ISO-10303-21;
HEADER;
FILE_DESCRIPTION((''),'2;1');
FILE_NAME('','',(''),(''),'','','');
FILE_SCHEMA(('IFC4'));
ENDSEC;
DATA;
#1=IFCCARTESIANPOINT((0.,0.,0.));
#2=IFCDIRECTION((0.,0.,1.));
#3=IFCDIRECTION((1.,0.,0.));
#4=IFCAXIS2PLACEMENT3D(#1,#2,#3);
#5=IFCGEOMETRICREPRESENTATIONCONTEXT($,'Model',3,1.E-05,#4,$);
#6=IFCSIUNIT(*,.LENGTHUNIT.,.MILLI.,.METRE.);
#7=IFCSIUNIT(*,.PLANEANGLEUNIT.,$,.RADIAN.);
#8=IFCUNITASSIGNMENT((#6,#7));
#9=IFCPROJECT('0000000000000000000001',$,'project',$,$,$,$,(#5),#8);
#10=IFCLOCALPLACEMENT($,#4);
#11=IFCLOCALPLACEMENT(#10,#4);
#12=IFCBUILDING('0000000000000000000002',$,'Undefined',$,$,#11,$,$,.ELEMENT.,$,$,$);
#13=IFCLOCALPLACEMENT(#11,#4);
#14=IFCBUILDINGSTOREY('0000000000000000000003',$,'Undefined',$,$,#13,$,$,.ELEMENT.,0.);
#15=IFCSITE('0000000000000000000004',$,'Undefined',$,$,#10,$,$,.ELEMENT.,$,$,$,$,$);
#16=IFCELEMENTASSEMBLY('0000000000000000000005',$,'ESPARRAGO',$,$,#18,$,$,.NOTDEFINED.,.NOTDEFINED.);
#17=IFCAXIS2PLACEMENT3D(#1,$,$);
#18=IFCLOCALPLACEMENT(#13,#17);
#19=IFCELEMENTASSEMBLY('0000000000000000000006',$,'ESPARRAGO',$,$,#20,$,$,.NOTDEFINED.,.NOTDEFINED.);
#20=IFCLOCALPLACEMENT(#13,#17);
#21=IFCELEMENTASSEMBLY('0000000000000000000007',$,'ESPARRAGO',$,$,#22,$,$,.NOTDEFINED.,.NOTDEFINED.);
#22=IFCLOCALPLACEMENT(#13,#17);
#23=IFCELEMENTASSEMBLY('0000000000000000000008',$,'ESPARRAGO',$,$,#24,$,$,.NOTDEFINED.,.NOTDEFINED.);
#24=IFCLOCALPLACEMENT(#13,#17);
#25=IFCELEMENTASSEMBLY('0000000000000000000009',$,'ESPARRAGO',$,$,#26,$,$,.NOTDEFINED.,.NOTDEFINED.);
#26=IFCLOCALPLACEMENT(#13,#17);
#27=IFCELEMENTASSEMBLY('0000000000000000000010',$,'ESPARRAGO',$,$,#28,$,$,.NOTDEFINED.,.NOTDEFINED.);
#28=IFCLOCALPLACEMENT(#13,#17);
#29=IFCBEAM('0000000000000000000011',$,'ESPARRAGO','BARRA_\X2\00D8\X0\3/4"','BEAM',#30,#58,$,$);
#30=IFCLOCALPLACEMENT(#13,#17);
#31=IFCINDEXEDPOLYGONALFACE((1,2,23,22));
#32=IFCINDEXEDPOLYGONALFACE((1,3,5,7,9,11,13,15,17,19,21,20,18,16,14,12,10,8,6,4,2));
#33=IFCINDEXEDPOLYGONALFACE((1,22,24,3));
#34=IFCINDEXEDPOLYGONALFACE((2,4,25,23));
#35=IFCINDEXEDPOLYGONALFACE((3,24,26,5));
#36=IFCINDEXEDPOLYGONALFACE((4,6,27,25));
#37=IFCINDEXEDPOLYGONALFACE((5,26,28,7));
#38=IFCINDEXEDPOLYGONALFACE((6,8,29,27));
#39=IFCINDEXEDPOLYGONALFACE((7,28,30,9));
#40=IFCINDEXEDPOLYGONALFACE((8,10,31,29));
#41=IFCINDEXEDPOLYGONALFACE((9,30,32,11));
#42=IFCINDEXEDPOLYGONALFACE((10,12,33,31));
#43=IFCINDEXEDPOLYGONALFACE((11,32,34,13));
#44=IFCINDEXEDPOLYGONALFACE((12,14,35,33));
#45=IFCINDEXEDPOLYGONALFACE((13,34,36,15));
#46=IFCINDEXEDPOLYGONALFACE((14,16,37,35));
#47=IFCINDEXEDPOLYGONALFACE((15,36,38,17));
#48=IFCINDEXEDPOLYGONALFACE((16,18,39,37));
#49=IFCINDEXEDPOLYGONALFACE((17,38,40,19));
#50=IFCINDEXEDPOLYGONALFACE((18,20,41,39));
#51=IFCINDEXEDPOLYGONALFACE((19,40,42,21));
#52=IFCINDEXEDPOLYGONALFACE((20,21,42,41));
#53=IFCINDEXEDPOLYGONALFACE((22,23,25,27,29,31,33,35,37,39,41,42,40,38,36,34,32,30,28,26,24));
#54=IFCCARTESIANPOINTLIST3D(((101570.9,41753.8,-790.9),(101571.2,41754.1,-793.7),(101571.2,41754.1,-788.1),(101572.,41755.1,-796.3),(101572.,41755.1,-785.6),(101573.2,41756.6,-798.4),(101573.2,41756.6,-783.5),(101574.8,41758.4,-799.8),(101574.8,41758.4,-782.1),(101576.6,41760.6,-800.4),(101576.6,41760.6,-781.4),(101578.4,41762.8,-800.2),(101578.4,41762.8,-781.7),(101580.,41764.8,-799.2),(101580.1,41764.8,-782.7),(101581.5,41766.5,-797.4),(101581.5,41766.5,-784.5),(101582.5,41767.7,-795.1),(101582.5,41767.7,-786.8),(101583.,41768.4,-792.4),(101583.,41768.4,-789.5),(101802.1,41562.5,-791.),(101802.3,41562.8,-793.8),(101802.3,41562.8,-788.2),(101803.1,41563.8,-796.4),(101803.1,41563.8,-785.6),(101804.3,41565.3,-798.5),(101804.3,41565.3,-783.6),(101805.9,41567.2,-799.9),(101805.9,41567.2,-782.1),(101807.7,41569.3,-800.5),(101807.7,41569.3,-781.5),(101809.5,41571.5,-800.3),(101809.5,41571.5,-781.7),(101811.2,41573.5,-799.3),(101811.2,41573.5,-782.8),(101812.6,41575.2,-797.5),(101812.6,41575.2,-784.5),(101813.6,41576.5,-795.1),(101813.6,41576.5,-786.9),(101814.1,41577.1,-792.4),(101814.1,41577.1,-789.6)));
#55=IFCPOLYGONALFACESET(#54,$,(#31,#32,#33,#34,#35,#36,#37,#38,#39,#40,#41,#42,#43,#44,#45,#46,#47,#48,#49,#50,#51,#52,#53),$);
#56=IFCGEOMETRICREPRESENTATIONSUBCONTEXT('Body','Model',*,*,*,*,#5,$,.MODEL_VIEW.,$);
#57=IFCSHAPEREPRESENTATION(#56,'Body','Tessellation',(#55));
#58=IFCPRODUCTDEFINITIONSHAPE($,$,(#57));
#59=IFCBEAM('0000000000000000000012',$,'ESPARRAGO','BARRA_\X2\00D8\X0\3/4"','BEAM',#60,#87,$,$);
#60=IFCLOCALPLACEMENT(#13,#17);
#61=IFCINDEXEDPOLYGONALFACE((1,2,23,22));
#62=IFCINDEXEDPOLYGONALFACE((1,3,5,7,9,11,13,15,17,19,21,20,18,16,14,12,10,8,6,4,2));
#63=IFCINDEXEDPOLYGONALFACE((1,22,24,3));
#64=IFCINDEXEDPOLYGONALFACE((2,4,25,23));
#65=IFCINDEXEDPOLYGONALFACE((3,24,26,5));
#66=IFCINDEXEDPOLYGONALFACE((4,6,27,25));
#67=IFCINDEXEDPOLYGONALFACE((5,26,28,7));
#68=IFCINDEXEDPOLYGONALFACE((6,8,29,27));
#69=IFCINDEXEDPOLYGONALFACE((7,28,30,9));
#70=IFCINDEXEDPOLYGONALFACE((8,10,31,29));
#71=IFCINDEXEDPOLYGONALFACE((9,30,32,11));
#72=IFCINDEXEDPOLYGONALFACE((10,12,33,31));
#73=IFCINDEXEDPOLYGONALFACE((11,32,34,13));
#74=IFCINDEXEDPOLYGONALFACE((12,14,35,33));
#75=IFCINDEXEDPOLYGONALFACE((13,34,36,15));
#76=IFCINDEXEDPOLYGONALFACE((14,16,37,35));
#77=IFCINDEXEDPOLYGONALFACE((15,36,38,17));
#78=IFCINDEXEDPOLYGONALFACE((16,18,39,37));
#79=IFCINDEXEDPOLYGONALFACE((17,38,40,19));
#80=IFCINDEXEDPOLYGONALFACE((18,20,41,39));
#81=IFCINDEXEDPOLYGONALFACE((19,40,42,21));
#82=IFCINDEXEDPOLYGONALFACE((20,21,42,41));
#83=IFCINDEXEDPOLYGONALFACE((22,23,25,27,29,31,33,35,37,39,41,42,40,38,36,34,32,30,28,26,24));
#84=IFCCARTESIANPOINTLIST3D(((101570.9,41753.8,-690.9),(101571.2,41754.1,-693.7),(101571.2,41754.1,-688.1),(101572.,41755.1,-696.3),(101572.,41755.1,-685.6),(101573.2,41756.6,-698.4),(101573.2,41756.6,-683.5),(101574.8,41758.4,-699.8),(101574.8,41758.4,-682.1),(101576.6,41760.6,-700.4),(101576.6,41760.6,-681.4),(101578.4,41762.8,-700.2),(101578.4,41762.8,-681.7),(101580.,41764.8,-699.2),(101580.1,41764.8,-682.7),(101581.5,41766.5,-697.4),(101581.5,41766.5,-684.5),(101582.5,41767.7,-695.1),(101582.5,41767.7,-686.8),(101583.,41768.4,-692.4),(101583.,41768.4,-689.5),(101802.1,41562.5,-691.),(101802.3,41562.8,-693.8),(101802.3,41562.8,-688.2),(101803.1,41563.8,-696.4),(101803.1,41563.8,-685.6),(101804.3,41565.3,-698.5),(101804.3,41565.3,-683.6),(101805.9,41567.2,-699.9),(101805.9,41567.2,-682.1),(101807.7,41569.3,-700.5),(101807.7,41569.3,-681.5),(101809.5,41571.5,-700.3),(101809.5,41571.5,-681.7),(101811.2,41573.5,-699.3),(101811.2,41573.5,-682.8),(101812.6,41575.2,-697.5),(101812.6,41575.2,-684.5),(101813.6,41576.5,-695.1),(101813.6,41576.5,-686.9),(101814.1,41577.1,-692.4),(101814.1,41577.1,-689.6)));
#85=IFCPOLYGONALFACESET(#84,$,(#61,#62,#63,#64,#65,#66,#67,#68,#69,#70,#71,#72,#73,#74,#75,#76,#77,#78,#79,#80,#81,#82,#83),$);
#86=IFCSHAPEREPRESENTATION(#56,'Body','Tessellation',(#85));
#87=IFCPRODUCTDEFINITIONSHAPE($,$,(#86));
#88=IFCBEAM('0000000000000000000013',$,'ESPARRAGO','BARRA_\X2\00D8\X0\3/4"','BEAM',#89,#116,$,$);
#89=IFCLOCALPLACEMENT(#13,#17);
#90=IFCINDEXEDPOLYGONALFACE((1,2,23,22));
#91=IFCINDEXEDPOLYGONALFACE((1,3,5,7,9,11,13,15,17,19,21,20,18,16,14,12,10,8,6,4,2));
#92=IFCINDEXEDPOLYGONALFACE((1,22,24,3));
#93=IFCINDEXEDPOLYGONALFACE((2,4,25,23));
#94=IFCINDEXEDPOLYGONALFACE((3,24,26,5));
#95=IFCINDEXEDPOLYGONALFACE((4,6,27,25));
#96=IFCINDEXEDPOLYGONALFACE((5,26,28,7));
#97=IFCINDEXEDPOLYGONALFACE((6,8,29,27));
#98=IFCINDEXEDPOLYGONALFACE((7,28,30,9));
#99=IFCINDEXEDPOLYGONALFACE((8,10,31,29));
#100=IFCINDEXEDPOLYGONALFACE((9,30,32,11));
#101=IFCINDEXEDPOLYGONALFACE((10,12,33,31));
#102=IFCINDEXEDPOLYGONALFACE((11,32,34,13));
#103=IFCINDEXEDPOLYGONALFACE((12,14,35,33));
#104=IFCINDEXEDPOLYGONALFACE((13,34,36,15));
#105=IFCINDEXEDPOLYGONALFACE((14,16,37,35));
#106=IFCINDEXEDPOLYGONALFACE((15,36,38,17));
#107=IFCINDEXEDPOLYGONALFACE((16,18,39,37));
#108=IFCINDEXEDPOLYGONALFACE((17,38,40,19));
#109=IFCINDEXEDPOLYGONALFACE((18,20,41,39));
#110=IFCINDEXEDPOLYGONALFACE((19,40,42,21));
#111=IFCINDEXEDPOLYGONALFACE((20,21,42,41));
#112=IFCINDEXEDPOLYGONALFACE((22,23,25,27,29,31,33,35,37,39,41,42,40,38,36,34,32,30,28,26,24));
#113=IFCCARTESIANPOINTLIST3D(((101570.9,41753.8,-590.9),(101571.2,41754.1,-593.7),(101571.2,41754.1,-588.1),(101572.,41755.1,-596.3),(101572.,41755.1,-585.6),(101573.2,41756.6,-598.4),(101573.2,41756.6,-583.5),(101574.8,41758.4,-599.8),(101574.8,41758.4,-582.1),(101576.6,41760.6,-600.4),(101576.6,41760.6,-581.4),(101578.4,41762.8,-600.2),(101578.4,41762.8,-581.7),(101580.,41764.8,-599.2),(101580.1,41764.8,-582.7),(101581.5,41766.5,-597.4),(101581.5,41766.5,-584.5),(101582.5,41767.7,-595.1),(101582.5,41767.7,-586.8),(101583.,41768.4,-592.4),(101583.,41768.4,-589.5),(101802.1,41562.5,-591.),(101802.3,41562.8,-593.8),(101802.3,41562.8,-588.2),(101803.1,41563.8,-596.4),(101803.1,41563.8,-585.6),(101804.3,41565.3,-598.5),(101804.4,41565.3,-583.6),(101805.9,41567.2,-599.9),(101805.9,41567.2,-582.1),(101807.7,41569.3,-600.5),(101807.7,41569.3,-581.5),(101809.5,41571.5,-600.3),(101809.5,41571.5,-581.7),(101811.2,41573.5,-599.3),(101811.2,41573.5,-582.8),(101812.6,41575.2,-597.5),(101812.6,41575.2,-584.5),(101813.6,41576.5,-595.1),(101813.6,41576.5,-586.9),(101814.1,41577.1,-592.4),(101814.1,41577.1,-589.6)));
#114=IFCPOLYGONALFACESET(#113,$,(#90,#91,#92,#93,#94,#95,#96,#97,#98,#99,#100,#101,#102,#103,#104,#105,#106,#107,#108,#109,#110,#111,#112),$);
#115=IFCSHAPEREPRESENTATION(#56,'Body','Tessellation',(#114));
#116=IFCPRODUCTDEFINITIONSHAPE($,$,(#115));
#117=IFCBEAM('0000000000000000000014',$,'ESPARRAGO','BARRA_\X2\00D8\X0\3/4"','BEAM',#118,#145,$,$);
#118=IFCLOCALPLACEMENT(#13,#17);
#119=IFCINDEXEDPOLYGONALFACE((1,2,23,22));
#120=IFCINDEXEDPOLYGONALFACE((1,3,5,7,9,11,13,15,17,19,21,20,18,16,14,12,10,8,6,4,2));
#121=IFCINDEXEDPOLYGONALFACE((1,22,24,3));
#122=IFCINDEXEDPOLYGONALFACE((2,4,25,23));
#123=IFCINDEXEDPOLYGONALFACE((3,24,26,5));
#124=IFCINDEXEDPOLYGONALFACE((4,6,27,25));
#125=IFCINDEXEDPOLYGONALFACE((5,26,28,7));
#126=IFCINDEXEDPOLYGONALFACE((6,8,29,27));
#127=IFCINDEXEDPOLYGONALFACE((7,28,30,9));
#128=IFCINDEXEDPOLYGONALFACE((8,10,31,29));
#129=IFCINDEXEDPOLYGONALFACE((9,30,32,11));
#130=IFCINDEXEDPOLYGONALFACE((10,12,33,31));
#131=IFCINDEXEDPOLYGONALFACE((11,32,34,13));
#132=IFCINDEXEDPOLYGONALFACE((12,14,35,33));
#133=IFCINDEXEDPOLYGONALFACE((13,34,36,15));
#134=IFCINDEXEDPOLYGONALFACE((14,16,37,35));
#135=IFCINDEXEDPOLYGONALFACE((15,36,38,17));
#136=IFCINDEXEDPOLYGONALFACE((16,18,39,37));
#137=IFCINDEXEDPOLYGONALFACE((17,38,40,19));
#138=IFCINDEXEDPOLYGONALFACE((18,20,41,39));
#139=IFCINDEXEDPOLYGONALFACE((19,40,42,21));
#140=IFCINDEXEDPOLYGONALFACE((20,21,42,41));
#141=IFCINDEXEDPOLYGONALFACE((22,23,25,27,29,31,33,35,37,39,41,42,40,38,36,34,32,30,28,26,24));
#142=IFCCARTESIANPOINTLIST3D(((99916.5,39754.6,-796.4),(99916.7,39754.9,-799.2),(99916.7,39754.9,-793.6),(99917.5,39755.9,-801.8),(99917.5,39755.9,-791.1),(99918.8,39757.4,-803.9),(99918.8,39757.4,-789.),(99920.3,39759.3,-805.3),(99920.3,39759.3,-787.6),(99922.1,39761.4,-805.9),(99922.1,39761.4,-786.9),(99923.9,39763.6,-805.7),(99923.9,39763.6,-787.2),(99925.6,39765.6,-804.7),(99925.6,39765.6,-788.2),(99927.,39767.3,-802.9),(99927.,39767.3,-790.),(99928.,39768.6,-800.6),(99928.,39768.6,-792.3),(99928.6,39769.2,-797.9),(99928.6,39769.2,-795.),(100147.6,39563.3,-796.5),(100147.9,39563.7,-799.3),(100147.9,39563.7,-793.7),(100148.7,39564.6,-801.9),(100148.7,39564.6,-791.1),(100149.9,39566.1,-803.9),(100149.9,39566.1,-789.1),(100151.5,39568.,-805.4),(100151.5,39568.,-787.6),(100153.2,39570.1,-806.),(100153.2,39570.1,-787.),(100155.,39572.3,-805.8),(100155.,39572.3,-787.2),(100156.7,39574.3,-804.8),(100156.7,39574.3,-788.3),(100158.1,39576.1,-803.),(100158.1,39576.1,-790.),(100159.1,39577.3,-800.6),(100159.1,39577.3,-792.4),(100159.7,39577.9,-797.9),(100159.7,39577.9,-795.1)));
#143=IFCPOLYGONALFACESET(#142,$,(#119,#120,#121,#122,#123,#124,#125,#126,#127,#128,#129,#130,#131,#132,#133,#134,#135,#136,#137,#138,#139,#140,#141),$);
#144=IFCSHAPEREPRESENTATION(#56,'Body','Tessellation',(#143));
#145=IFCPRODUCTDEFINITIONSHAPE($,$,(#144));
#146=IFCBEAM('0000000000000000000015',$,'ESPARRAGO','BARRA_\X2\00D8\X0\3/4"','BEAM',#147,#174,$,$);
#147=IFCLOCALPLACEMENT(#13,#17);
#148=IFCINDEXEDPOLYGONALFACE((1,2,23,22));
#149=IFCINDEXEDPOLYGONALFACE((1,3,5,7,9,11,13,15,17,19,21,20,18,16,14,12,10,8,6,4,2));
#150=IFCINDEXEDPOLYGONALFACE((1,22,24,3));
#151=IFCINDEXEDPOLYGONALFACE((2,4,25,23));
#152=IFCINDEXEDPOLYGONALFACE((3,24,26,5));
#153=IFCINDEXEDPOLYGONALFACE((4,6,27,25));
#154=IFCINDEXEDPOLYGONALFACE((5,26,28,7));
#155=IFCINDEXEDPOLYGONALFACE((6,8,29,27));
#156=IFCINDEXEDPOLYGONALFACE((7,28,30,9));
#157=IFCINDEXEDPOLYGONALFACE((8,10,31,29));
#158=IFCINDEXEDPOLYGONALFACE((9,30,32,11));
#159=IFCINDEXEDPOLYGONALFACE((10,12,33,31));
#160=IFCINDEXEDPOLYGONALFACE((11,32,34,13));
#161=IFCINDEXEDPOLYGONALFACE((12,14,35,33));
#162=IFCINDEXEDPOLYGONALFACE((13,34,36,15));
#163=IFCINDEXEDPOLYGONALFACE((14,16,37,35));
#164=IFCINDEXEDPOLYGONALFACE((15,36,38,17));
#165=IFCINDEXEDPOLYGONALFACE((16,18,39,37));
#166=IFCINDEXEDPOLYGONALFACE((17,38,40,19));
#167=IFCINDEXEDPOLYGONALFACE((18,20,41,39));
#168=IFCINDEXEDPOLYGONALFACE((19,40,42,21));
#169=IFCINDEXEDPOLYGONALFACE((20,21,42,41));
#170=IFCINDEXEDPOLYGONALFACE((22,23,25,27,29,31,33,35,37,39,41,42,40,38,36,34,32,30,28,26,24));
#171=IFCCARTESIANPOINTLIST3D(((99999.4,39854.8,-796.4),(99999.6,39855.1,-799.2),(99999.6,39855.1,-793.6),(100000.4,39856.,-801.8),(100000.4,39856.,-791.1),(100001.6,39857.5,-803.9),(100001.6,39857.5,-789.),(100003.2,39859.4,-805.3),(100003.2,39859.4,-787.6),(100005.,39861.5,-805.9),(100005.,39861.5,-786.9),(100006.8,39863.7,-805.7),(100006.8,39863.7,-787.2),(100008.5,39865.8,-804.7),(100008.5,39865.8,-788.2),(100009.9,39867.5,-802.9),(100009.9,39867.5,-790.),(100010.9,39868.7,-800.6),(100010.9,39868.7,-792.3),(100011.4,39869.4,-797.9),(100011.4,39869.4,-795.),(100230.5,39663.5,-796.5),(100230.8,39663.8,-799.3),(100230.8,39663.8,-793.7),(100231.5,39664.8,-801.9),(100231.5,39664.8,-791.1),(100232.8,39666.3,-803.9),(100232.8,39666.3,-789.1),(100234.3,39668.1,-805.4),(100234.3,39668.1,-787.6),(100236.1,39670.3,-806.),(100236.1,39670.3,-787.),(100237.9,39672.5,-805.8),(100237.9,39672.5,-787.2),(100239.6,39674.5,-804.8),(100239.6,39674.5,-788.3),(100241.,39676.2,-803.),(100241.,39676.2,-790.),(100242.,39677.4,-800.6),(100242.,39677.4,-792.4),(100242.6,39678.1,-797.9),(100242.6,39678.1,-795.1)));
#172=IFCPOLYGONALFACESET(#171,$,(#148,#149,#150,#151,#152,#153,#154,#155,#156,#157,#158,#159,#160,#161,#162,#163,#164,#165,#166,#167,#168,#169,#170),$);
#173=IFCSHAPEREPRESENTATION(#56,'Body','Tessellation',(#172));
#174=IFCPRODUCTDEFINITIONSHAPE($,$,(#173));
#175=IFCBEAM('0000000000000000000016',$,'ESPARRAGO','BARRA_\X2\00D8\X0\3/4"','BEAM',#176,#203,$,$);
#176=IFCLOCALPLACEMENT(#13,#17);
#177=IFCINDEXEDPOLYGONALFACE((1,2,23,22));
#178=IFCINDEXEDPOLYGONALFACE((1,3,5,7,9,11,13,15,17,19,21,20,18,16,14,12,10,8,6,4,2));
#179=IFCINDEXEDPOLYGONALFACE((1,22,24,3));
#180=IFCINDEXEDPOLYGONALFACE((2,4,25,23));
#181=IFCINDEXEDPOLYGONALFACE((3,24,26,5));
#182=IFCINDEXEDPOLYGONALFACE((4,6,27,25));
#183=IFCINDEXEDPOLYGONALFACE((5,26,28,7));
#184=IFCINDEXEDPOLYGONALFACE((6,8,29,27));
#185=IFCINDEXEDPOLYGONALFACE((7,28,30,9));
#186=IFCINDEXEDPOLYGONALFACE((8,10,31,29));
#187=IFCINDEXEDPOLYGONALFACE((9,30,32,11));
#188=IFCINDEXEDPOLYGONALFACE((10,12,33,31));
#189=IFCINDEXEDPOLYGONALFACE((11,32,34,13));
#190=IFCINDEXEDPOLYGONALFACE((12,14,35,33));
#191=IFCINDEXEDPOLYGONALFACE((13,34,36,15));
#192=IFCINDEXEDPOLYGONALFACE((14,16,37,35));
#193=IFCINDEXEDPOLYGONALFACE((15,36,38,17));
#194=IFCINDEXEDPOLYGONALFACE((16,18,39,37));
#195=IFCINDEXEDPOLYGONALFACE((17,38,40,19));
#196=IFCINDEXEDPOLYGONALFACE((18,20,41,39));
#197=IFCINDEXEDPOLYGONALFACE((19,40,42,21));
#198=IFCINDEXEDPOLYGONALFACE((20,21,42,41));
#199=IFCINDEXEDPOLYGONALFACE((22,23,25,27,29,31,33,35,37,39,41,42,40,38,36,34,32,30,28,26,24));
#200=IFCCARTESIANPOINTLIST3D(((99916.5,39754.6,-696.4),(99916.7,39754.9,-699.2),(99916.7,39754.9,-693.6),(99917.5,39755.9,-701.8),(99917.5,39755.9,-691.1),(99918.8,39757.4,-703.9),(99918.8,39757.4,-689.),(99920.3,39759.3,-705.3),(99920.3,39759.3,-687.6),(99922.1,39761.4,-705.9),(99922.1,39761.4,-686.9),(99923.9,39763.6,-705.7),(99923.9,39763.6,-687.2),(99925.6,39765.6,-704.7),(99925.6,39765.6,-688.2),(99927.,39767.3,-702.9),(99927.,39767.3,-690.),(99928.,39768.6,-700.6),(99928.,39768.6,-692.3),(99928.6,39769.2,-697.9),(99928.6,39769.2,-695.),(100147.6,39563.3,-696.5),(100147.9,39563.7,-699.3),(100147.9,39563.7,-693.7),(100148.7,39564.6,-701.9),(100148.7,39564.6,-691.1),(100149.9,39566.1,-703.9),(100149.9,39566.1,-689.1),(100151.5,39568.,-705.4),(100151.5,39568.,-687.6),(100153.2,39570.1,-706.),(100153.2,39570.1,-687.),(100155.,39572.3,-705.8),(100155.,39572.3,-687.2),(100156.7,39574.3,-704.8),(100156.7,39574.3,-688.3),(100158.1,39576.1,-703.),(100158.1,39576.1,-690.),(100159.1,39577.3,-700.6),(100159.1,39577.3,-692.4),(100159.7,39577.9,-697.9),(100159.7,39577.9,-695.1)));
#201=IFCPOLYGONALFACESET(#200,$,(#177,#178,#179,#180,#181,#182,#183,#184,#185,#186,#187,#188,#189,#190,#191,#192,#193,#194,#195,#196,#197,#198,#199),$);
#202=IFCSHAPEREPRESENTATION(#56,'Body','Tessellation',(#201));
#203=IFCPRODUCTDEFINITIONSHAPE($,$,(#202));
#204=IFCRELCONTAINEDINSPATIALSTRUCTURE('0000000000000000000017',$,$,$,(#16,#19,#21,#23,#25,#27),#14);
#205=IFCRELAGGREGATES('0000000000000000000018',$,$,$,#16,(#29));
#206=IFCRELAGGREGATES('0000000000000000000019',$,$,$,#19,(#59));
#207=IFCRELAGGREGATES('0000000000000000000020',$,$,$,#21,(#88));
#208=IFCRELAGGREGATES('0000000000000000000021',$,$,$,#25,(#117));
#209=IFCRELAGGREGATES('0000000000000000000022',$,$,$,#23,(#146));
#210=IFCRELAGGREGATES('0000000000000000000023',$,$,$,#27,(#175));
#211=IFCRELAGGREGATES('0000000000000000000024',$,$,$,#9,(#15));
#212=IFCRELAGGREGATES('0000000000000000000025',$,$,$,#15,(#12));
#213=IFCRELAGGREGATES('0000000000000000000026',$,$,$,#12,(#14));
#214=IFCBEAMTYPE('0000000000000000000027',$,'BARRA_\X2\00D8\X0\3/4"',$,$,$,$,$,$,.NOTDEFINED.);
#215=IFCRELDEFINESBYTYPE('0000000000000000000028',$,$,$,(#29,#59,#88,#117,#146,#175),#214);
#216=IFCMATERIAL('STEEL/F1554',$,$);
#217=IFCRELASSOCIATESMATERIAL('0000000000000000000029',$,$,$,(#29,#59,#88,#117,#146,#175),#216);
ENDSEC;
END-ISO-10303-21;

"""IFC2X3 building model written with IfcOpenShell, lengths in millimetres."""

from ifc_helpers import new_model, si_unit, frame, origin_with_axes, origin_2d_with_axis, place, context, subcontext, project, spatial, circle, extrude, material, type_object, element, aggregate, save


model = new_model("IFC2X3")

# Units and contexts
model_context = context("Model", 3, precision=1e-05, world=origin_with_axes())
body_context = subcontext(model_context, "Body", "Model", "MODEL_VIEW")
ifc_project = project(units=[si_unit("LENGTHUNIT", "METRE", prefix="MILLI"), si_unit("PLANEANGLEUNIT", "RADIAN")], contexts=[model_context])

# Site, building, storey
site_placement = place(None, origin_with_axes())
site = spatial("IfcSite", under=ifc_project, at=site_placement, Name="Undefined", CompositionType="ELEMENT")
building_placement = place(site_placement, origin_with_axes())
building = spatial("IfcBuilding", under=site, at=building_placement, Name="Undefined", CompositionType="ELEMENT")
storey_placement = place(building_placement, origin_with_axes())
storey = spatial("IfcBuildingStorey", under=building, at=storey_placement, Name="Undefined", CompositionType="ELEMENT", Elevation=0.0)

# Element assemblies
assembly_1_placement = place(storey_placement, origin_with_axes())
assembly_1 = element("IfcElementAssembly", 1, at=assembly_1_placement, inside=storey, Name="ESPARRAGO", AssemblyPlace="NOTDEFINED", PredefinedType="NOTDEFINED")
assembly_2_placement = place(storey_placement, origin_with_axes())
assembly_2 = element("IfcElementAssembly", 2, at=assembly_2_placement, inside=storey, Name="ESPARRAGO", AssemblyPlace="NOTDEFINED", PredefinedType="NOTDEFINED")
assembly_3_placement = place(storey_placement, origin_with_axes())
assembly_3 = element("IfcElementAssembly", 3, at=assembly_3_placement, inside=storey, Name="ESPARRAGO", AssemblyPlace="NOTDEFINED", PredefinedType="NOTDEFINED")
assembly_4_placement = place(storey_placement, origin_with_axes())
assembly_4 = element("IfcElementAssembly", 4, at=assembly_4_placement, inside=storey, Name="ESPARRAGO", AssemblyPlace="NOTDEFINED", PredefinedType="NOTDEFINED")

# Element assembly
assembly_5_placement = place(storey_placement, origin_with_axes())
assembly_5 = element("IfcElementAssembly", 5, at=assembly_5_placement, inside=storey, Name="ESPARRAGO", AssemblyPlace="NOTDEFINED", PredefinedType="NOTDEFINED")

# Element assembly
assembly_6_placement = place(storey_placement, origin_with_axes())
assembly_6 = element("IfcElementAssembly", 6, at=assembly_6_placement, inside=storey, Name="ESPARRAGO", AssemblyPlace="NOTDEFINED", PredefinedType="NOTDEFINED")

# Beams
ifc_material_1 = material(Name="STEEL/F1554")
beam_type_1 = type_object("IfcBeamType", Name="BARRA_Ø3/4\"", PredefinedType="NOTDEFINED")
beam_1_placement = place(assembly_1_placement, frame((101577.0, 41761.1, -790.9), z_axis=(0.000162, -0.000134, 1.0), x_axis=(0.770403, -0.637558, -0.000211)))
beam_1 = element("IfcBeam", 7, at=beam_1_placement, type_object=beam_type_1, material=ifc_material_1, Name="ESPARRAGO", Description="BARRA_Ø3/4\"", ObjectType="BEAM", context=body_context, shape_type="SweptSolid", body=[
    extrude(circle(Radius=9.5, at=origin_2d_with_axis()), frame((300.0, 0.0, 0.0), z_axis=(-1.0, 0.0, 0.0), x_axis=(0.0, -1.0, 0.0)), (0.0, 0.0, 1.0), 300.0),
])
aggregate(assembly_1, [beam_1])
beam_2_placement = place(assembly_2_placement, frame((101577.0, 41761.1, -690.9), z_axis=(0.000162, -0.000134, 1.0), x_axis=(0.770403, -0.637558, -0.000211)))
beam_2 = element("IfcBeam", 8, at=beam_2_placement, type_object=beam_type_1, material=ifc_material_1, Name="ESPARRAGO", Description="BARRA_Ø3/4\"", ObjectType="BEAM", context=body_context, shape_type="SweptSolid", body=[
    extrude(circle(Radius=9.5, at=origin_2d_with_axis()), frame((300.0, 0.0, 0.0), z_axis=(-1.0, 0.0, 0.0), x_axis=(0.0, -1.0, 0.0)), (0.0, 0.0, 1.0), 300.0),
])
aggregate(assembly_2, [beam_2])
beam_3_placement = place(assembly_3_placement, frame((101577.0, 41761.1, -590.9), z_axis=(0.000162, -0.000134, 1.0), x_axis=(0.770403, -0.637558, -0.000211)))
beam_3 = element("IfcBeam", 9, at=beam_3_placement, type_object=beam_type_1, material=ifc_material_1, Name="ESPARRAGO", Description="BARRA_Ø3/4\"", ObjectType="BEAM", context=body_context, shape_type="SweptSolid", body=[
    extrude(circle(Radius=9.5, at=origin_2d_with_axis()), frame((300.0, 0.0, 0.0), z_axis=(-1.0, 0.0, 0.0), x_axis=(0.0, -1.0, 0.0)), (0.0, 0.0, 1.0), 300.0),
])
aggregate(assembly_3, [beam_3])
beam_4_placement = place(assembly_5_placement, frame((99922.6, 39761.9, -796.4), z_axis=(0.000162, -0.000134, 1.0), x_axis=(0.770403, -0.637558, -0.000211)))
beam_4 = element("IfcBeam", 10, at=beam_4_placement, type_object=beam_type_1, material=ifc_material_1, Name="ESPARRAGO", Description="BARRA_Ø3/4\"", ObjectType="BEAM", context=body_context, shape_type="SweptSolid", body=[
    extrude(circle(Radius=9.5, at=origin_2d_with_axis()), frame((300.0, 0.0, 0.0), z_axis=(-1.0, 0.0, 0.0), x_axis=(0.0, -1.0, 0.0)), (0.0, 0.0, 1.0), 300.0),
])
aggregate(assembly_5, [beam_4])
beam_5_placement = place(assembly_4_placement, frame((100005.4, 39862.1, -796.4), z_axis=(0.000162, -0.000134, 1.0), x_axis=(0.770403, -0.637558, -0.000211)))
beam_5 = element("IfcBeam", 11, at=beam_5_placement, type_object=beam_type_1, material=ifc_material_1, Name="ESPARRAGO", Description="BARRA_Ø3/4\"", ObjectType="BEAM", context=body_context, shape_type="SweptSolid", body=[
    extrude(circle(Radius=9.5, at=origin_2d_with_axis()), frame((300.0, 0.0, 0.0), z_axis=(-1.0, 0.0, 0.0), x_axis=(0.0, -1.0, 0.0)), (0.0, 0.0, 1.0), 300.0),
])
aggregate(assembly_4, [beam_5])
beam_6_placement = place(assembly_6_placement, frame((99922.6, 39761.9, -696.4), z_axis=(0.000162, -0.000134, 1.0), x_axis=(0.770403, -0.637558, -0.000211)))
beam_6 = element("IfcBeam", 12, at=beam_6_placement, type_object=beam_type_1, material=ifc_material_1, Name="ESPARRAGO", Description="BARRA_Ø3/4\"", ObjectType="BEAM", context=body_context, shape_type="SweptSolid", body=[
    extrude(circle(Radius=9.5, at=origin_2d_with_axis()), frame((300.0, 0.0, 0.0), z_axis=(-1.0, 0.0, 0.0), x_axis=(0.0, -1.0, 0.0)), (0.0, 0.0, 1.0), 300.0),
])
aggregate(assembly_6, [beam_6])

save(model, "model.ifc")
